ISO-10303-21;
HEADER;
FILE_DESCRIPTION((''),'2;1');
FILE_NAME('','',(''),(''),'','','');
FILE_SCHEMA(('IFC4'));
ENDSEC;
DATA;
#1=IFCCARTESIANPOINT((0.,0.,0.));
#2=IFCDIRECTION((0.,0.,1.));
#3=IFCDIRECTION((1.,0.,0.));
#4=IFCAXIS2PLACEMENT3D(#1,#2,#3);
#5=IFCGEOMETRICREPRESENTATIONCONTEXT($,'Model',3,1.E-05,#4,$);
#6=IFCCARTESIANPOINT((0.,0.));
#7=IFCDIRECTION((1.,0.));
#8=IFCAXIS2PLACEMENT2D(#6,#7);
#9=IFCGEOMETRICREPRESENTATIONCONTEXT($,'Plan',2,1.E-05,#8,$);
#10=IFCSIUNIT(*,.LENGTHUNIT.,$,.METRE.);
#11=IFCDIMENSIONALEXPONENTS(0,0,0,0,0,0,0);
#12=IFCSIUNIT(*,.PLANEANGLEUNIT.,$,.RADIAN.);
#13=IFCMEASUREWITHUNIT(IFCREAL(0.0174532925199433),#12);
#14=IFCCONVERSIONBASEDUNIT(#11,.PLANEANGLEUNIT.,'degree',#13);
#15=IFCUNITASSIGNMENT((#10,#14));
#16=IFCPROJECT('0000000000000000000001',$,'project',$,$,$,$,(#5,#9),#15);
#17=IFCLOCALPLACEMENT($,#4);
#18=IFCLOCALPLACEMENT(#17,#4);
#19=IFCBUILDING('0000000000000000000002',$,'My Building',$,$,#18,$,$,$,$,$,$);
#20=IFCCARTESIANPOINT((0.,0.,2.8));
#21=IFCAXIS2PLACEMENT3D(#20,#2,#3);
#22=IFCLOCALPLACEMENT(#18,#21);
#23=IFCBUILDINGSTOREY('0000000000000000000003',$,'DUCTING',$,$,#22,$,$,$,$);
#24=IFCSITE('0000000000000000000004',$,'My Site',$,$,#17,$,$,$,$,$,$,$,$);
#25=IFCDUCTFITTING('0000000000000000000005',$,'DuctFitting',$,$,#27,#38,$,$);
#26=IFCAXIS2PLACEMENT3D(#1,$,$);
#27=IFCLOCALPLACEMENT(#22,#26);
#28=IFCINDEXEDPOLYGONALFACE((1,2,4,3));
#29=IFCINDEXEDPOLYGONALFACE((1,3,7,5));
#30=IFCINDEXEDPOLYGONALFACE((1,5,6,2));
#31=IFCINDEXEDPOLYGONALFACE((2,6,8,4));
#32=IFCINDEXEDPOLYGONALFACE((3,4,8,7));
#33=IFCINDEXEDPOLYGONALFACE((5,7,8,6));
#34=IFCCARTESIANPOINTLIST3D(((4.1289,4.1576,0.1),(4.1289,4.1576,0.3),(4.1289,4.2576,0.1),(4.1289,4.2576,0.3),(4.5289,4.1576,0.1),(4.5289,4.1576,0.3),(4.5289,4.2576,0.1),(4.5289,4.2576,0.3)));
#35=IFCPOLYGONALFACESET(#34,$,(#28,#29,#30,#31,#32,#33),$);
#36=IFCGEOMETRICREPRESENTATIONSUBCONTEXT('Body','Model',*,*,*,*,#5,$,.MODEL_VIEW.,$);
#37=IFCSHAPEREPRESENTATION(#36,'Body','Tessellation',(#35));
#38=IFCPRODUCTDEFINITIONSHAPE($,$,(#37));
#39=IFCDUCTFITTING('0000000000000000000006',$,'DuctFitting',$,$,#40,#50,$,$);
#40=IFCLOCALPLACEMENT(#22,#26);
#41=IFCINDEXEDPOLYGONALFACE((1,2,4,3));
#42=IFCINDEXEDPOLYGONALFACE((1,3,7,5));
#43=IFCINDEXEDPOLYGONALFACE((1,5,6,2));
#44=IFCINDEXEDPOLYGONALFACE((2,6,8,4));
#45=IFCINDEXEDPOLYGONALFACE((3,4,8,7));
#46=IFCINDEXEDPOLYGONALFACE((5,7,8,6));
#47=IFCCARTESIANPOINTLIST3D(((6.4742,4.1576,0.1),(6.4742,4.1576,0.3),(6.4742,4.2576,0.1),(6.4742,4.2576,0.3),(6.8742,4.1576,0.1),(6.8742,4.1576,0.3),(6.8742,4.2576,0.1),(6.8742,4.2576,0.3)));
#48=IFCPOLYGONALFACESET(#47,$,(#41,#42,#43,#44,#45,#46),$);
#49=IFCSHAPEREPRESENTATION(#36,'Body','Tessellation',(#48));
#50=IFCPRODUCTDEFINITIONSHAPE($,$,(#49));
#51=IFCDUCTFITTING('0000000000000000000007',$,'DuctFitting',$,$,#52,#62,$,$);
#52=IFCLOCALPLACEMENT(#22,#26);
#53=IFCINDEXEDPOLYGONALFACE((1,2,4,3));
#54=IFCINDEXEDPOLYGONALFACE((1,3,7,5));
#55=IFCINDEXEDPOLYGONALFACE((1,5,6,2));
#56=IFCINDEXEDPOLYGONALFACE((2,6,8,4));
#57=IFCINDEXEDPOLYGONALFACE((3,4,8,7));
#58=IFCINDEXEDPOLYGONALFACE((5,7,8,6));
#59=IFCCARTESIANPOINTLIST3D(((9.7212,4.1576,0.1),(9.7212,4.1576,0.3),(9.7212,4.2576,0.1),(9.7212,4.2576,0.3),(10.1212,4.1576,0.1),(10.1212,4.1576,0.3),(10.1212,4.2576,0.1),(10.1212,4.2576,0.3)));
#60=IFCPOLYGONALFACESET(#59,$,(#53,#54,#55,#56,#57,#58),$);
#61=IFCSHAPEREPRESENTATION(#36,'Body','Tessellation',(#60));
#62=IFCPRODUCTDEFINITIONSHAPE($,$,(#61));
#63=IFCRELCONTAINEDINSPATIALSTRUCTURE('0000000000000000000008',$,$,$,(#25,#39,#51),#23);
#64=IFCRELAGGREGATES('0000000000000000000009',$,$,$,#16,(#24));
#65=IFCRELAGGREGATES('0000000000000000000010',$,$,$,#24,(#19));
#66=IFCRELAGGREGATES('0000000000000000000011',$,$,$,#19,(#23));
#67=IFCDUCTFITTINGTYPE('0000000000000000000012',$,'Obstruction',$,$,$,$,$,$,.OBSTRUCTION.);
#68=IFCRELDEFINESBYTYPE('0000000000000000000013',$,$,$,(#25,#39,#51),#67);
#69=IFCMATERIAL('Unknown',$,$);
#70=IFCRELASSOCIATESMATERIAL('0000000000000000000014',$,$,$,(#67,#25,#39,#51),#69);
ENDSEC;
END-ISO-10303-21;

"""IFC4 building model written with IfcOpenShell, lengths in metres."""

from ifc_helpers import new_model, entity, si_unit, converted_unit, frame, origin_with_axes, origin_2d_with_axis, place, context, subcontext, project, spatial, rectangle, extrude, material, material_profile, profile_set, profile_usage, type_object, element, save


model = new_model("IFC4")

# Units and contexts
model_context = context("Model", 3, precision=1e-05, world=origin_with_axes())
plan_context = context("Plan", 2, precision=1e-05, world=origin_2d_with_axis())
body_context = subcontext(model_context, "Body", "Model", "MODEL_VIEW")
ifc_project = project(units=[si_unit("LENGTHUNIT", "METRE"), converted_unit("PLANEANGLEUNIT", "degree", entity("IfcReal", 0.0174532925199433), si_unit("PLANEANGLEUNIT", "RADIAN"), dimensions=[0, 0, 0, 0, 0, 0, 0])], contexts=[model_context, plan_context])

# Site, building, storey
site_placement = place(None, origin_with_axes())
site = spatial("IfcSite", under=ifc_project, at=site_placement, Name="My Site")
building_placement = place(site_placement, origin_with_axes())
building = spatial("IfcBuilding", under=site, at=building_placement, Name="My Building")
storey_placement = place(building_placement, frame((0.0, 0.0, 2.8), z_axis=(0.0, 0.0, 1.0), x_axis=(1.0, 0.0, 0.0)))
storey = spatial("IfcBuildingStorey", under=building, at=storey_placement, Name="DUCTING")

# Shared definitions
ifc_material = material(Name="Unknown")

# Duct fittings
ifc_material_profile_1 = material_profile(ifc_material, rectangle(XDim=0.4, YDim=0.2))
ifc_profile_set_1 = profile_set([ifc_material_profile_1])
duct_fitting_type_1 = type_object("IfcDuctFittingType", Name="Obstruction", PredefinedType="OBSTRUCTION", material=ifc_profile_set_1)
ifc_profile_usage_1 = profile_usage(ifc_profile_set_1, cardinal=5)
duct_fitting_1_placement = place(storey_placement, frame((4.3289, 4.2576, 0.2), z_axis=(0.0, -1.0, 0.0), x_axis=(1.0, 0.0, 0.0)))
element("IfcDuctFitting", 1, at=duct_fitting_1_placement, inside=storey, type_object=duct_fitting_type_1, material=ifc_profile_usage_1, Name="DuctFitting", context=body_context, shape_type="SweptSolid", body=[
    extrude(rectangle(XDim=0.4, YDim=0.2), origin_with_axes(), (0.0, 0.0, 1.0), 0.1),
])
ifc_profile_usage_2 = profile_usage(ifc_profile_set_1, cardinal=5)
duct_fitting_2_placement = place(storey_placement, frame((6.6742, 4.2576, 0.2), z_axis=(0.0, -1.0, 0.0), x_axis=(1.0, 0.0, 0.0)))
element("IfcDuctFitting", 2, at=duct_fitting_2_placement, inside=storey, type_object=duct_fitting_type_1, material=ifc_profile_usage_2, Name="DuctFitting", context=body_context, shape_type="SweptSolid", body=[
    extrude(rectangle(XDim=0.4, YDim=0.2), origin_with_axes(), (0.0, 0.0, 1.0), 0.1),
])
ifc_profile_usage_3 = profile_usage(ifc_profile_set_1, cardinal=5)
duct_fitting_3_placement = place(storey_placement, frame((9.9212, 4.2576, 0.2), z_axis=(0.0, -1.0, 0.0), x_axis=(1.0, 0.0, 0.0)))
element("IfcDuctFitting", 3, at=duct_fitting_3_placement, inside=storey, type_object=duct_fitting_type_1, material=ifc_profile_usage_3, Name="DuctFitting", context=body_context, shape_type="SweptSolid", body=[
    extrude(rectangle(XDim=0.4, YDim=0.2), origin_with_axes(), (0.0, 0.0, 1.0), 0.1),
])

save(model, "model.ifc")
